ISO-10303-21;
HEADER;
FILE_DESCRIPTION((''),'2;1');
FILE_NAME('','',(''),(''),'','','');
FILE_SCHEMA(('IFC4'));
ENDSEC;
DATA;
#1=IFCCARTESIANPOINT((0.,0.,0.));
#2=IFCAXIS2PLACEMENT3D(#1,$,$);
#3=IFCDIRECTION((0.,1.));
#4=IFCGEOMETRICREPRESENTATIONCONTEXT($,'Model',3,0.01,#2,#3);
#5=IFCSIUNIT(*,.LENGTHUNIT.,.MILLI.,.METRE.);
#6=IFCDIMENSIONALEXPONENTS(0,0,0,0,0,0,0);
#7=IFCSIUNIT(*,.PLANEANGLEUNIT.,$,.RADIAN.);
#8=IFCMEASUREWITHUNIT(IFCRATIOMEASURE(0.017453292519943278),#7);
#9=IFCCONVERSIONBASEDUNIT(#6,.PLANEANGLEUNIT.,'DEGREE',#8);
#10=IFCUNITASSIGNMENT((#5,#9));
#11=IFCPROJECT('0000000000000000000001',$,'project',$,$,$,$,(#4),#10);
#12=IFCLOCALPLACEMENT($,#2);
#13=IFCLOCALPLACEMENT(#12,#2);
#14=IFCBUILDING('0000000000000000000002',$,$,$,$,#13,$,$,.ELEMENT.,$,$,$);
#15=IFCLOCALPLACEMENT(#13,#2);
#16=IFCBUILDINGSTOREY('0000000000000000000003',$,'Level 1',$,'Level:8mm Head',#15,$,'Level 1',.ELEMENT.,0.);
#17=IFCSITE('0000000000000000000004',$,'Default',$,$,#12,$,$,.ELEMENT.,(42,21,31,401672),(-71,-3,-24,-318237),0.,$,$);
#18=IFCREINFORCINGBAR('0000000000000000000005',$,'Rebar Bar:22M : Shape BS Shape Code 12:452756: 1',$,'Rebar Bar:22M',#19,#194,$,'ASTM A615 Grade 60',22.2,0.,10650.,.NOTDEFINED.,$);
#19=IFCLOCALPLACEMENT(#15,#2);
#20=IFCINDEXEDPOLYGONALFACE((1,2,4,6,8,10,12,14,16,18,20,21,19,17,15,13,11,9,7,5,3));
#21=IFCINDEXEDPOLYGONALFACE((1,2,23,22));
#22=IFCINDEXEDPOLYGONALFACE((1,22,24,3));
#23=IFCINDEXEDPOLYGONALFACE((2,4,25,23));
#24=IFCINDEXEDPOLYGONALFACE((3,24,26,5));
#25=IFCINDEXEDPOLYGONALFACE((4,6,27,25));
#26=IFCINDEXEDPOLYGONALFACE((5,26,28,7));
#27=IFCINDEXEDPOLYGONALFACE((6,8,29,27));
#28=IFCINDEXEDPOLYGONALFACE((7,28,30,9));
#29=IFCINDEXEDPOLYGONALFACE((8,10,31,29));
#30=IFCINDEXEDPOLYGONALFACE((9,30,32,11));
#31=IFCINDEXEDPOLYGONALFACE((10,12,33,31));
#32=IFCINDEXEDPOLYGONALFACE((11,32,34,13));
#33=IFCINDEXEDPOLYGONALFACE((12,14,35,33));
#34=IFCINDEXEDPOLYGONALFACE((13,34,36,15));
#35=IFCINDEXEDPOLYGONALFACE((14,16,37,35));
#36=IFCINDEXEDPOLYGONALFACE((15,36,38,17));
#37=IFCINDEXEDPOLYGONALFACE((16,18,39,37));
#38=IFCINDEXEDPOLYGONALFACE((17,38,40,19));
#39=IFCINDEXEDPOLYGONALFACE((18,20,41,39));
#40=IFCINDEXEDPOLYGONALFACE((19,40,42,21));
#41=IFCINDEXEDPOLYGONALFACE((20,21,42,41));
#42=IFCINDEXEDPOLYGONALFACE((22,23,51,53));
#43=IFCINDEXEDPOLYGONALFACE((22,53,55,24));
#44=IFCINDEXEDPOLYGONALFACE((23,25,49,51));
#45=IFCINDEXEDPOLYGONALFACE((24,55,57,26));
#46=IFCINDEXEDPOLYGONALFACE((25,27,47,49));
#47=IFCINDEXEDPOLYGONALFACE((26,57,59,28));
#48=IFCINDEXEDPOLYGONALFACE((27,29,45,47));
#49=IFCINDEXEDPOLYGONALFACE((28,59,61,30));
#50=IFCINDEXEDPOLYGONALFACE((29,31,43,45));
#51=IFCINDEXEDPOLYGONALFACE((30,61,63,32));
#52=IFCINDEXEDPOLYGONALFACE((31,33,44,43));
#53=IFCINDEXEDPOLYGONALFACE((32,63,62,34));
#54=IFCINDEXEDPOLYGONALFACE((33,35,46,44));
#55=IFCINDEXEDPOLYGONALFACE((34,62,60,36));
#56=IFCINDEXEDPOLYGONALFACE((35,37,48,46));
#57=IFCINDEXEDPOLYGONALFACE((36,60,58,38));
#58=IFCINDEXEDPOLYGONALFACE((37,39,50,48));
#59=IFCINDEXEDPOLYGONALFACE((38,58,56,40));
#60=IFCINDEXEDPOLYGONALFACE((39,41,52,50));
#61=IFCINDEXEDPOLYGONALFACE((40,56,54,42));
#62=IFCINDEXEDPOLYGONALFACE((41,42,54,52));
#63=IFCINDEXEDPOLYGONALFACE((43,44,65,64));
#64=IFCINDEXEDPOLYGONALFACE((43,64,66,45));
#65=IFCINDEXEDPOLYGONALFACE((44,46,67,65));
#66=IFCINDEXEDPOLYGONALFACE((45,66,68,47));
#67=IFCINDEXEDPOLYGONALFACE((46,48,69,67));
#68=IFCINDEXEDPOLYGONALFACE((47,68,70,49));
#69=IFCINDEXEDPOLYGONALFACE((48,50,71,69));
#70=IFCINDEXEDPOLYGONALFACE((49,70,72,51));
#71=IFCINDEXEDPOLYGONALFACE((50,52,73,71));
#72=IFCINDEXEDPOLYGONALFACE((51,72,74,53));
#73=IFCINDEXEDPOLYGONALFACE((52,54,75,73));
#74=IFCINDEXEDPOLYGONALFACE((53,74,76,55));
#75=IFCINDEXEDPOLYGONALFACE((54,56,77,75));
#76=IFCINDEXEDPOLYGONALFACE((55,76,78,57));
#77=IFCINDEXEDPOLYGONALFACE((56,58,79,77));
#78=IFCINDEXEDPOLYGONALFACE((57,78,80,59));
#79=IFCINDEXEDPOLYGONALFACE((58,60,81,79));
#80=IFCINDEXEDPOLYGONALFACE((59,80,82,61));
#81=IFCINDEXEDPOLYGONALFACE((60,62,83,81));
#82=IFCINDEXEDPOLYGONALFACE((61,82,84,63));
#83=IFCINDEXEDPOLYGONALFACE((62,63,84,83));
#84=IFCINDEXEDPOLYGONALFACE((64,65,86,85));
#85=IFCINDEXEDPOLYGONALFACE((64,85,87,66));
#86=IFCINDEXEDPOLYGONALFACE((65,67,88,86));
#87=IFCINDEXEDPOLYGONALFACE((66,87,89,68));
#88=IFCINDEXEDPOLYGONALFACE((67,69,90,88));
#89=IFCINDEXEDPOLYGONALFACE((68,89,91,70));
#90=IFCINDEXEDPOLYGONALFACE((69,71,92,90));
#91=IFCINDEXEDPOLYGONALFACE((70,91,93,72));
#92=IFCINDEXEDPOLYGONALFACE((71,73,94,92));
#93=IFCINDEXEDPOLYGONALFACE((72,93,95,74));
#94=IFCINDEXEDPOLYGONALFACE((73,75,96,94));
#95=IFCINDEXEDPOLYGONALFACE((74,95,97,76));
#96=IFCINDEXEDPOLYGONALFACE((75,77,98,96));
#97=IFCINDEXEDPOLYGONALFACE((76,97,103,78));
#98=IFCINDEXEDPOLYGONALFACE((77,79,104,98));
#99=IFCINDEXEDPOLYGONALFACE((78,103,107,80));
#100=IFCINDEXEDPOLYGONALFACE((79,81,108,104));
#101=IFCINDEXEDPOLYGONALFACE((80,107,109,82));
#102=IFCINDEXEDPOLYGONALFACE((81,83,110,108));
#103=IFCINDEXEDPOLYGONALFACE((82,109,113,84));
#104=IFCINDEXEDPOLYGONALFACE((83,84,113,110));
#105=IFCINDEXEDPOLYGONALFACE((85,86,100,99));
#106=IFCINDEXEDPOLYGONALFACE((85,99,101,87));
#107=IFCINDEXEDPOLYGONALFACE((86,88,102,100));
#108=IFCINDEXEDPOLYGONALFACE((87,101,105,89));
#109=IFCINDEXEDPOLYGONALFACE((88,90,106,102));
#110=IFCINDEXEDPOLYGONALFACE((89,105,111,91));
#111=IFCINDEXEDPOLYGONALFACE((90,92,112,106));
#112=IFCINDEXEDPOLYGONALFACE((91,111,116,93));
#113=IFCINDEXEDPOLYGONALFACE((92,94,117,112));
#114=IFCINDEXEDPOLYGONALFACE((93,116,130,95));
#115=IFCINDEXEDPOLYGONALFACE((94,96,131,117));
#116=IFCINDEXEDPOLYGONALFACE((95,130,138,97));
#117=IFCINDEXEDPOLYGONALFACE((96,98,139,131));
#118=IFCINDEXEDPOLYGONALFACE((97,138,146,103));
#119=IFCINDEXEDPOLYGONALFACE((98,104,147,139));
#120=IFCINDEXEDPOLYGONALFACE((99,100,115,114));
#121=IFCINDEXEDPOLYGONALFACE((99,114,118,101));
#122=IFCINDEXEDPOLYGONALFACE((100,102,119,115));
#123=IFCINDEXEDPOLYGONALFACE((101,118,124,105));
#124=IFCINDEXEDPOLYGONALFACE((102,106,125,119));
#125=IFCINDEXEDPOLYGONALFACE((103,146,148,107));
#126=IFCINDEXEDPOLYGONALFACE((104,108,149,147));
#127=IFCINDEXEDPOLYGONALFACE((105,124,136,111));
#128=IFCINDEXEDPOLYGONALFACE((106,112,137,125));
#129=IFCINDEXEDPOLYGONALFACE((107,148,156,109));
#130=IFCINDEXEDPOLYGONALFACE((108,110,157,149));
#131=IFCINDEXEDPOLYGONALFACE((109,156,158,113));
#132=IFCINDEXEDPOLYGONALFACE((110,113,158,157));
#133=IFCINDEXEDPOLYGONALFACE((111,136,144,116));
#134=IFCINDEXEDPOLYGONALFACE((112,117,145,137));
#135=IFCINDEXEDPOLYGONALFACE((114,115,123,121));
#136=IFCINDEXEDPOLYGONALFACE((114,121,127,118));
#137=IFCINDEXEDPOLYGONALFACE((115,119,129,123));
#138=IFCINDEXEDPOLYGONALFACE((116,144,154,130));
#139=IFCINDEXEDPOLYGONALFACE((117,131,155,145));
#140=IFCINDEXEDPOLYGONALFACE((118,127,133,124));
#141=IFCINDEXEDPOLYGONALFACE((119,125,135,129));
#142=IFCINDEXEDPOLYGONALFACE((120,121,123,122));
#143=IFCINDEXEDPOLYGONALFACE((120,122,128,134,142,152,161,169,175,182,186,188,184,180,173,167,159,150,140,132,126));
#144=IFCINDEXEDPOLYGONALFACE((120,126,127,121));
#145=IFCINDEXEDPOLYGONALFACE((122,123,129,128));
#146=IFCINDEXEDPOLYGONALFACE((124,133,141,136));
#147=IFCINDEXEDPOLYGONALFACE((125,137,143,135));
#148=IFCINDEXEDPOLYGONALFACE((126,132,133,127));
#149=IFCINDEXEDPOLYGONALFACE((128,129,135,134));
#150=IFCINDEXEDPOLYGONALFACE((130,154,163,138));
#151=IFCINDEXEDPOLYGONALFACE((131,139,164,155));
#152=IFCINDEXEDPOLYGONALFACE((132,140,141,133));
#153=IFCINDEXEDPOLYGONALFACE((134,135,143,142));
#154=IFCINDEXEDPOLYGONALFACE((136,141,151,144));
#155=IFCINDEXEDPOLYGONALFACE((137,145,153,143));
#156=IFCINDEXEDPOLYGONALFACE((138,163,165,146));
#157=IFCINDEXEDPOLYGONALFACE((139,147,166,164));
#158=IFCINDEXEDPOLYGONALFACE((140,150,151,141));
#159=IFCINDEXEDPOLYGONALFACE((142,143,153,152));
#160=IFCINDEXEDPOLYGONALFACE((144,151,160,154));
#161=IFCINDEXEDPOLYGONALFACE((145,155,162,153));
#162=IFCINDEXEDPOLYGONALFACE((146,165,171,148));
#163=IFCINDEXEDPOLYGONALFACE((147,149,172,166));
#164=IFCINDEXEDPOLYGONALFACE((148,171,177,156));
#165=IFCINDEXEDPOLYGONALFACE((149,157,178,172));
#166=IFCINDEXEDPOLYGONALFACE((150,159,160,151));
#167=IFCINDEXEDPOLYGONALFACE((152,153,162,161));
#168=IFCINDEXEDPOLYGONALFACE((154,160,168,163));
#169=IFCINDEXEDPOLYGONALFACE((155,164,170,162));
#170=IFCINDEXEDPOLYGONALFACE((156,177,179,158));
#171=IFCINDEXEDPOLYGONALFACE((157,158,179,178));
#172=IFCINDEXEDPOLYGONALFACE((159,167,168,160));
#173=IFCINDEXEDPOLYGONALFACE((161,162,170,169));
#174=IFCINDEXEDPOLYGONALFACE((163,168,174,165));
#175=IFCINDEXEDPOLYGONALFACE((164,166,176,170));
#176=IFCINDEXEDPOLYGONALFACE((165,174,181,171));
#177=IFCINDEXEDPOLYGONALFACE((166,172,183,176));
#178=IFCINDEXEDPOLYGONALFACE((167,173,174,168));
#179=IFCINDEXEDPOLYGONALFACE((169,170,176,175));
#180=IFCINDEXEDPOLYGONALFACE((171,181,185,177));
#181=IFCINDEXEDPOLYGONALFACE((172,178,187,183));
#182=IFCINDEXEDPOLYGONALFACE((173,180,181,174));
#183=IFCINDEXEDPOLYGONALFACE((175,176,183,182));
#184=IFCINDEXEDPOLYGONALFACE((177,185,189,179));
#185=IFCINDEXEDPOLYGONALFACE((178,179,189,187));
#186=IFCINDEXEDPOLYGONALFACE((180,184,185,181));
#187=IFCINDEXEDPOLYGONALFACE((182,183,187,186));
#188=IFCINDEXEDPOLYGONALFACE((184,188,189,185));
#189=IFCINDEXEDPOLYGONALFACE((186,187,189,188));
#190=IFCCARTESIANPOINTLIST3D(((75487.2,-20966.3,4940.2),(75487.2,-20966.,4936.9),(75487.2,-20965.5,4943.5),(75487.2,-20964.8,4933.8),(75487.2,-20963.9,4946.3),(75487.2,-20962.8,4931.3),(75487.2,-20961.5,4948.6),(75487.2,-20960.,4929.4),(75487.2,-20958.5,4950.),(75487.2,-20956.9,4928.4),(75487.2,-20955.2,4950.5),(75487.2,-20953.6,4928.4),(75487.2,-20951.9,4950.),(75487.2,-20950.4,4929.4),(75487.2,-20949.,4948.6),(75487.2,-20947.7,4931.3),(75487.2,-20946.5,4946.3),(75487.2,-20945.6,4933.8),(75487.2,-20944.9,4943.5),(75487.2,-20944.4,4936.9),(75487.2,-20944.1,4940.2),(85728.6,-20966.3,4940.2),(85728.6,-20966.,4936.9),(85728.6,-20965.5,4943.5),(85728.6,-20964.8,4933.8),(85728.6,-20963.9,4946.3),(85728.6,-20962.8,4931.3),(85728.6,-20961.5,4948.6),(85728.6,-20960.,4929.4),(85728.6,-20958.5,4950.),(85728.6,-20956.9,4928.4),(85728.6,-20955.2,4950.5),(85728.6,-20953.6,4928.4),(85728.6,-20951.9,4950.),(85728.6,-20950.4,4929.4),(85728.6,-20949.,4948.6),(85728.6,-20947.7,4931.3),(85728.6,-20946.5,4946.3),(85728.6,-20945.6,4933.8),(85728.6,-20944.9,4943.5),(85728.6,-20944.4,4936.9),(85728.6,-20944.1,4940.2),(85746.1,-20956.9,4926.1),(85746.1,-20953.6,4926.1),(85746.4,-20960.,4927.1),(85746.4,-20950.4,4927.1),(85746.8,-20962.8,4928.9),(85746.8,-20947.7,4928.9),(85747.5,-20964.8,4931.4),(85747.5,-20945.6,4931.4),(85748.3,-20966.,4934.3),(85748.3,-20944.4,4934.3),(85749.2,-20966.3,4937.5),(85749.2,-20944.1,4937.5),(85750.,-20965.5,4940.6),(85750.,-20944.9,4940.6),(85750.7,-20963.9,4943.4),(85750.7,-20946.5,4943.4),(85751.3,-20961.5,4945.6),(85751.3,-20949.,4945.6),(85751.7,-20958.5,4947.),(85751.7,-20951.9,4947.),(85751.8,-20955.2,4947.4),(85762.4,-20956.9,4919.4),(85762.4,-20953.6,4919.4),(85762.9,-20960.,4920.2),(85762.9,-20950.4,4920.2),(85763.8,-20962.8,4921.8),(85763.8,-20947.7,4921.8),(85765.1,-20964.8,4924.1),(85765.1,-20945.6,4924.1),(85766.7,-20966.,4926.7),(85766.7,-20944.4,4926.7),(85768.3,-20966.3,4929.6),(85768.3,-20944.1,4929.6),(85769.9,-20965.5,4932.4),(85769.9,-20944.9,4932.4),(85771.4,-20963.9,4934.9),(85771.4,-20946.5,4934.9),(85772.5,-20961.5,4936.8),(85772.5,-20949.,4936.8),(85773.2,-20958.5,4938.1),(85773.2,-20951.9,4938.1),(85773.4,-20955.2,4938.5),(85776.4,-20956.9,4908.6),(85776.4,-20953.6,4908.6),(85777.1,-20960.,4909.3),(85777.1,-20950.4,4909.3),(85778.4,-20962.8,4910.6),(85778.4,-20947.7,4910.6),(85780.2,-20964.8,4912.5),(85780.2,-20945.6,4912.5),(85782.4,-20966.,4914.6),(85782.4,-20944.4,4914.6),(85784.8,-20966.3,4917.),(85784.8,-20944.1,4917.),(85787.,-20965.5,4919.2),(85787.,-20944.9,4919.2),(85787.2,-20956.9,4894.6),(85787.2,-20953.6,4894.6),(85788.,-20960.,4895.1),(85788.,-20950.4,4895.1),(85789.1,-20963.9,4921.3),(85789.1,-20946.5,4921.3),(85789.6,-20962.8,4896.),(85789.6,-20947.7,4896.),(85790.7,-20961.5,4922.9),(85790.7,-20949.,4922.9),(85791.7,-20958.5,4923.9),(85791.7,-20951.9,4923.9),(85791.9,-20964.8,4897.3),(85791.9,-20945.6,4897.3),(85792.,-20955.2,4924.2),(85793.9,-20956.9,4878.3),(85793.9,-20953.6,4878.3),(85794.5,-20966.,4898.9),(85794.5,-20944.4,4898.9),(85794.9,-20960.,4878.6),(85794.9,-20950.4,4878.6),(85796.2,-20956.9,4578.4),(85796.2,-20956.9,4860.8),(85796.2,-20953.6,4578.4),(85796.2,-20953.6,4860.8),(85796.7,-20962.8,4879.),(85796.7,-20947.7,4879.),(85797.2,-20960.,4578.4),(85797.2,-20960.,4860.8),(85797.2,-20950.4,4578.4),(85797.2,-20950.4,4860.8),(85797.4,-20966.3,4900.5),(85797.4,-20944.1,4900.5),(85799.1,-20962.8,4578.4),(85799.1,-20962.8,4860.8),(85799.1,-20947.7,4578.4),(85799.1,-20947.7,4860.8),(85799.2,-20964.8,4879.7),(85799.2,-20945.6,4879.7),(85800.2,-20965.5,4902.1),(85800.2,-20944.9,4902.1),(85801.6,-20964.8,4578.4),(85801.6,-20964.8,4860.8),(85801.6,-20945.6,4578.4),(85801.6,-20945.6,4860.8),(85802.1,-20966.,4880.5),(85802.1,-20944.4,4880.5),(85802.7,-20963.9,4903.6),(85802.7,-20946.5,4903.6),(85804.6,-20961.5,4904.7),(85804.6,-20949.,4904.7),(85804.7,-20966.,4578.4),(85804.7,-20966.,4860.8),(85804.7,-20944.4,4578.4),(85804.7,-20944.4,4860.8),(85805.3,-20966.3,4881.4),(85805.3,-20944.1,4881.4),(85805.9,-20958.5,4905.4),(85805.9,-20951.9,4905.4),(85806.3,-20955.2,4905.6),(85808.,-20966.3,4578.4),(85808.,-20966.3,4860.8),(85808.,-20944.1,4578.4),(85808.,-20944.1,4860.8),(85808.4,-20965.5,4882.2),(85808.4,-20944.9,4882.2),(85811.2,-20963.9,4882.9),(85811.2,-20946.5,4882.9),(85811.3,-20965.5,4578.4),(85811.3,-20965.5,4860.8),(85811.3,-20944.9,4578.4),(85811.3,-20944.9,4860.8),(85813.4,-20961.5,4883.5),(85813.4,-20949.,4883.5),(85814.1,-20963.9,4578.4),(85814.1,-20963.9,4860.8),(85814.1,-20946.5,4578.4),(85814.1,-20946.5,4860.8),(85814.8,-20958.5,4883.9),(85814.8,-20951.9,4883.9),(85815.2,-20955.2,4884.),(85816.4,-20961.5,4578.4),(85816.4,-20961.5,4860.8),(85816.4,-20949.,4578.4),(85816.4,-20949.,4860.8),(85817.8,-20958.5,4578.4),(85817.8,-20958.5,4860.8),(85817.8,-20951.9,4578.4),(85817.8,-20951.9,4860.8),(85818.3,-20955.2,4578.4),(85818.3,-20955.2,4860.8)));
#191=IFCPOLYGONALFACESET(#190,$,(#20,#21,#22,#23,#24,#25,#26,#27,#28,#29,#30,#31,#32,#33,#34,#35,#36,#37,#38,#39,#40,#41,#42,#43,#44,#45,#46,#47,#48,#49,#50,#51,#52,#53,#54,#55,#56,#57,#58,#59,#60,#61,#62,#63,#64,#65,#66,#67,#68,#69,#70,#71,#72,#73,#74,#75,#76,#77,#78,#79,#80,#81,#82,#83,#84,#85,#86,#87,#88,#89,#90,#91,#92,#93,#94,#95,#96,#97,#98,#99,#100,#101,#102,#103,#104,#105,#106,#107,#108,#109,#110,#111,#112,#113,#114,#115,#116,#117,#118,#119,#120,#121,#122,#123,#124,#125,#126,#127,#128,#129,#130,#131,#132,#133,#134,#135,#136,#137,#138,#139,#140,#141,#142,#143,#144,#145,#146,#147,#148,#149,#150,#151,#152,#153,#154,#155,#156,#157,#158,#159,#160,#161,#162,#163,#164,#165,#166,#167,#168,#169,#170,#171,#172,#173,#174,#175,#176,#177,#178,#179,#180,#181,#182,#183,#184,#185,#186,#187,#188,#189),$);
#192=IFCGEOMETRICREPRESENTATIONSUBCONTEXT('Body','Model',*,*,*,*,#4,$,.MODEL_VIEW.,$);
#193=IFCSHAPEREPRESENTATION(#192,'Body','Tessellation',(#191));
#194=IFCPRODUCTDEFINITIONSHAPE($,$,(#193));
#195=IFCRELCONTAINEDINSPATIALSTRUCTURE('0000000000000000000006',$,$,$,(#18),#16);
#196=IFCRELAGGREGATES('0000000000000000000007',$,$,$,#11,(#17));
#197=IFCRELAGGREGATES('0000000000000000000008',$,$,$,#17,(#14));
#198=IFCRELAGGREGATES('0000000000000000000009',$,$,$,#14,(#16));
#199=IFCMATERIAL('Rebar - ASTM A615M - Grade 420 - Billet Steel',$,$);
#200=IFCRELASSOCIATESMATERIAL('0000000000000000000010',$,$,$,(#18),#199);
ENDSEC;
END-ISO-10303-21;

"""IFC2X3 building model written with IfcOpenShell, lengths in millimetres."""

from ifc_helpers import new_model, entity, si_unit, converted_unit, direction, origin, place, context, subcontext, project, spatial, material, element, save


model = new_model("IFC2X3")

# Units and contexts
model_context = context("Model", 3, precision=0.01, world=origin(), true_north=direction((0.0, 1.0)))
body_context = subcontext(model_context, "Body", "Model", "MODEL_VIEW")
ifc_project = project(units=[si_unit("LENGTHUNIT", "METRE", prefix="MILLI"), converted_unit("PLANEANGLEUNIT", "DEGREE", entity("IfcRatioMeasure", 0.017453292519943278), si_unit("PLANEANGLEUNIT", "RADIAN"), dimensions=[0, 0, 0, 0, 0, 0, 0])], contexts=[model_context])

# Site, building, storey
site_placement = place(None, origin())
site = spatial("IfcSite", under=ifc_project, at=site_placement, Name="Default", CompositionType="ELEMENT", RefLatitude=(42, 21, 31, 401672), RefLongitude=(-71, -3, -24, -318237), RefElevation=0.0)
building_placement = place(site_placement, origin())
building = spatial("IfcBuilding", under=site, at=building_placement, CompositionType="ELEMENT")
storey_placement = place(building_placement, origin())
storey = spatial("IfcBuildingStorey", under=building, at=storey_placement, Name="Level 1", ObjectType="Level:8mm Head", LongName="Level 1", CompositionType="ELEMENT", Elevation=0.0)

# Reinforcing bar
ifc_material = material(Name="Rebar - ASTM A615M - Grade 420 - Billet Steel")
reinforcing_bar_1_placement = place(storey_placement, origin())
element("IfcReinforcingBar", 1, at=reinforcing_bar_1_placement, inside=storey, material=ifc_material, Name="Rebar Bar:22M : Shape BS Shape Code 12:452756: 1", SteelGrade="ASTM A615 Grade 60", ObjectType="Rebar Bar:22M", BarLength=10650.0, BarRole="NOTDEFINED", CrossSectionArea=0.0, NominalDiameter=22.2, context=body_context, shape_type="AdvancedSweptSolid", body=[
    entity("IfcSweptDiskSolid", entity("IfcCompositeCurve", [entity("IfcCompositeCurveSegment", "CONTINUOUS", True, entity("IfcPolyline", [entity("IfcCartesianPoint", [75487.2, -20955.2, 4939.4]), entity("IfcCartesianPoint", [85728.6, -20955.2, 4939.4])])), entity("IfcCompositeCurveSegment", "CONTINUOUS", True, entity("IfcTrimmedCurve", entity("IfcCircle", entity("IfcAxis2Placement3D", entity("IfcCartesianPoint", [85728.6, -20955.2, 4860.8]), entity("IfcDirection", [0.0, 1.0, 0.0]), entity("IfcDirection", [1.0, 0.0, 0.0])), 78.6), [entity("IfcParameterValue", 270.0)], [entity("IfcParameterValue", 360.0)], True, "PARAMETER")), entity("IfcCompositeCurveSegment", "CONTINUOUS", True, entity("IfcPolyline", [entity("IfcCartesianPoint", [85807.2, -20955.2, 4860.8]), entity("IfcCartesianPoint", [85807.2, -20955.2, 4578.4])]))], False), 11.1, None, 0.0, 92.0),
])

save(model, "model.ifc")
